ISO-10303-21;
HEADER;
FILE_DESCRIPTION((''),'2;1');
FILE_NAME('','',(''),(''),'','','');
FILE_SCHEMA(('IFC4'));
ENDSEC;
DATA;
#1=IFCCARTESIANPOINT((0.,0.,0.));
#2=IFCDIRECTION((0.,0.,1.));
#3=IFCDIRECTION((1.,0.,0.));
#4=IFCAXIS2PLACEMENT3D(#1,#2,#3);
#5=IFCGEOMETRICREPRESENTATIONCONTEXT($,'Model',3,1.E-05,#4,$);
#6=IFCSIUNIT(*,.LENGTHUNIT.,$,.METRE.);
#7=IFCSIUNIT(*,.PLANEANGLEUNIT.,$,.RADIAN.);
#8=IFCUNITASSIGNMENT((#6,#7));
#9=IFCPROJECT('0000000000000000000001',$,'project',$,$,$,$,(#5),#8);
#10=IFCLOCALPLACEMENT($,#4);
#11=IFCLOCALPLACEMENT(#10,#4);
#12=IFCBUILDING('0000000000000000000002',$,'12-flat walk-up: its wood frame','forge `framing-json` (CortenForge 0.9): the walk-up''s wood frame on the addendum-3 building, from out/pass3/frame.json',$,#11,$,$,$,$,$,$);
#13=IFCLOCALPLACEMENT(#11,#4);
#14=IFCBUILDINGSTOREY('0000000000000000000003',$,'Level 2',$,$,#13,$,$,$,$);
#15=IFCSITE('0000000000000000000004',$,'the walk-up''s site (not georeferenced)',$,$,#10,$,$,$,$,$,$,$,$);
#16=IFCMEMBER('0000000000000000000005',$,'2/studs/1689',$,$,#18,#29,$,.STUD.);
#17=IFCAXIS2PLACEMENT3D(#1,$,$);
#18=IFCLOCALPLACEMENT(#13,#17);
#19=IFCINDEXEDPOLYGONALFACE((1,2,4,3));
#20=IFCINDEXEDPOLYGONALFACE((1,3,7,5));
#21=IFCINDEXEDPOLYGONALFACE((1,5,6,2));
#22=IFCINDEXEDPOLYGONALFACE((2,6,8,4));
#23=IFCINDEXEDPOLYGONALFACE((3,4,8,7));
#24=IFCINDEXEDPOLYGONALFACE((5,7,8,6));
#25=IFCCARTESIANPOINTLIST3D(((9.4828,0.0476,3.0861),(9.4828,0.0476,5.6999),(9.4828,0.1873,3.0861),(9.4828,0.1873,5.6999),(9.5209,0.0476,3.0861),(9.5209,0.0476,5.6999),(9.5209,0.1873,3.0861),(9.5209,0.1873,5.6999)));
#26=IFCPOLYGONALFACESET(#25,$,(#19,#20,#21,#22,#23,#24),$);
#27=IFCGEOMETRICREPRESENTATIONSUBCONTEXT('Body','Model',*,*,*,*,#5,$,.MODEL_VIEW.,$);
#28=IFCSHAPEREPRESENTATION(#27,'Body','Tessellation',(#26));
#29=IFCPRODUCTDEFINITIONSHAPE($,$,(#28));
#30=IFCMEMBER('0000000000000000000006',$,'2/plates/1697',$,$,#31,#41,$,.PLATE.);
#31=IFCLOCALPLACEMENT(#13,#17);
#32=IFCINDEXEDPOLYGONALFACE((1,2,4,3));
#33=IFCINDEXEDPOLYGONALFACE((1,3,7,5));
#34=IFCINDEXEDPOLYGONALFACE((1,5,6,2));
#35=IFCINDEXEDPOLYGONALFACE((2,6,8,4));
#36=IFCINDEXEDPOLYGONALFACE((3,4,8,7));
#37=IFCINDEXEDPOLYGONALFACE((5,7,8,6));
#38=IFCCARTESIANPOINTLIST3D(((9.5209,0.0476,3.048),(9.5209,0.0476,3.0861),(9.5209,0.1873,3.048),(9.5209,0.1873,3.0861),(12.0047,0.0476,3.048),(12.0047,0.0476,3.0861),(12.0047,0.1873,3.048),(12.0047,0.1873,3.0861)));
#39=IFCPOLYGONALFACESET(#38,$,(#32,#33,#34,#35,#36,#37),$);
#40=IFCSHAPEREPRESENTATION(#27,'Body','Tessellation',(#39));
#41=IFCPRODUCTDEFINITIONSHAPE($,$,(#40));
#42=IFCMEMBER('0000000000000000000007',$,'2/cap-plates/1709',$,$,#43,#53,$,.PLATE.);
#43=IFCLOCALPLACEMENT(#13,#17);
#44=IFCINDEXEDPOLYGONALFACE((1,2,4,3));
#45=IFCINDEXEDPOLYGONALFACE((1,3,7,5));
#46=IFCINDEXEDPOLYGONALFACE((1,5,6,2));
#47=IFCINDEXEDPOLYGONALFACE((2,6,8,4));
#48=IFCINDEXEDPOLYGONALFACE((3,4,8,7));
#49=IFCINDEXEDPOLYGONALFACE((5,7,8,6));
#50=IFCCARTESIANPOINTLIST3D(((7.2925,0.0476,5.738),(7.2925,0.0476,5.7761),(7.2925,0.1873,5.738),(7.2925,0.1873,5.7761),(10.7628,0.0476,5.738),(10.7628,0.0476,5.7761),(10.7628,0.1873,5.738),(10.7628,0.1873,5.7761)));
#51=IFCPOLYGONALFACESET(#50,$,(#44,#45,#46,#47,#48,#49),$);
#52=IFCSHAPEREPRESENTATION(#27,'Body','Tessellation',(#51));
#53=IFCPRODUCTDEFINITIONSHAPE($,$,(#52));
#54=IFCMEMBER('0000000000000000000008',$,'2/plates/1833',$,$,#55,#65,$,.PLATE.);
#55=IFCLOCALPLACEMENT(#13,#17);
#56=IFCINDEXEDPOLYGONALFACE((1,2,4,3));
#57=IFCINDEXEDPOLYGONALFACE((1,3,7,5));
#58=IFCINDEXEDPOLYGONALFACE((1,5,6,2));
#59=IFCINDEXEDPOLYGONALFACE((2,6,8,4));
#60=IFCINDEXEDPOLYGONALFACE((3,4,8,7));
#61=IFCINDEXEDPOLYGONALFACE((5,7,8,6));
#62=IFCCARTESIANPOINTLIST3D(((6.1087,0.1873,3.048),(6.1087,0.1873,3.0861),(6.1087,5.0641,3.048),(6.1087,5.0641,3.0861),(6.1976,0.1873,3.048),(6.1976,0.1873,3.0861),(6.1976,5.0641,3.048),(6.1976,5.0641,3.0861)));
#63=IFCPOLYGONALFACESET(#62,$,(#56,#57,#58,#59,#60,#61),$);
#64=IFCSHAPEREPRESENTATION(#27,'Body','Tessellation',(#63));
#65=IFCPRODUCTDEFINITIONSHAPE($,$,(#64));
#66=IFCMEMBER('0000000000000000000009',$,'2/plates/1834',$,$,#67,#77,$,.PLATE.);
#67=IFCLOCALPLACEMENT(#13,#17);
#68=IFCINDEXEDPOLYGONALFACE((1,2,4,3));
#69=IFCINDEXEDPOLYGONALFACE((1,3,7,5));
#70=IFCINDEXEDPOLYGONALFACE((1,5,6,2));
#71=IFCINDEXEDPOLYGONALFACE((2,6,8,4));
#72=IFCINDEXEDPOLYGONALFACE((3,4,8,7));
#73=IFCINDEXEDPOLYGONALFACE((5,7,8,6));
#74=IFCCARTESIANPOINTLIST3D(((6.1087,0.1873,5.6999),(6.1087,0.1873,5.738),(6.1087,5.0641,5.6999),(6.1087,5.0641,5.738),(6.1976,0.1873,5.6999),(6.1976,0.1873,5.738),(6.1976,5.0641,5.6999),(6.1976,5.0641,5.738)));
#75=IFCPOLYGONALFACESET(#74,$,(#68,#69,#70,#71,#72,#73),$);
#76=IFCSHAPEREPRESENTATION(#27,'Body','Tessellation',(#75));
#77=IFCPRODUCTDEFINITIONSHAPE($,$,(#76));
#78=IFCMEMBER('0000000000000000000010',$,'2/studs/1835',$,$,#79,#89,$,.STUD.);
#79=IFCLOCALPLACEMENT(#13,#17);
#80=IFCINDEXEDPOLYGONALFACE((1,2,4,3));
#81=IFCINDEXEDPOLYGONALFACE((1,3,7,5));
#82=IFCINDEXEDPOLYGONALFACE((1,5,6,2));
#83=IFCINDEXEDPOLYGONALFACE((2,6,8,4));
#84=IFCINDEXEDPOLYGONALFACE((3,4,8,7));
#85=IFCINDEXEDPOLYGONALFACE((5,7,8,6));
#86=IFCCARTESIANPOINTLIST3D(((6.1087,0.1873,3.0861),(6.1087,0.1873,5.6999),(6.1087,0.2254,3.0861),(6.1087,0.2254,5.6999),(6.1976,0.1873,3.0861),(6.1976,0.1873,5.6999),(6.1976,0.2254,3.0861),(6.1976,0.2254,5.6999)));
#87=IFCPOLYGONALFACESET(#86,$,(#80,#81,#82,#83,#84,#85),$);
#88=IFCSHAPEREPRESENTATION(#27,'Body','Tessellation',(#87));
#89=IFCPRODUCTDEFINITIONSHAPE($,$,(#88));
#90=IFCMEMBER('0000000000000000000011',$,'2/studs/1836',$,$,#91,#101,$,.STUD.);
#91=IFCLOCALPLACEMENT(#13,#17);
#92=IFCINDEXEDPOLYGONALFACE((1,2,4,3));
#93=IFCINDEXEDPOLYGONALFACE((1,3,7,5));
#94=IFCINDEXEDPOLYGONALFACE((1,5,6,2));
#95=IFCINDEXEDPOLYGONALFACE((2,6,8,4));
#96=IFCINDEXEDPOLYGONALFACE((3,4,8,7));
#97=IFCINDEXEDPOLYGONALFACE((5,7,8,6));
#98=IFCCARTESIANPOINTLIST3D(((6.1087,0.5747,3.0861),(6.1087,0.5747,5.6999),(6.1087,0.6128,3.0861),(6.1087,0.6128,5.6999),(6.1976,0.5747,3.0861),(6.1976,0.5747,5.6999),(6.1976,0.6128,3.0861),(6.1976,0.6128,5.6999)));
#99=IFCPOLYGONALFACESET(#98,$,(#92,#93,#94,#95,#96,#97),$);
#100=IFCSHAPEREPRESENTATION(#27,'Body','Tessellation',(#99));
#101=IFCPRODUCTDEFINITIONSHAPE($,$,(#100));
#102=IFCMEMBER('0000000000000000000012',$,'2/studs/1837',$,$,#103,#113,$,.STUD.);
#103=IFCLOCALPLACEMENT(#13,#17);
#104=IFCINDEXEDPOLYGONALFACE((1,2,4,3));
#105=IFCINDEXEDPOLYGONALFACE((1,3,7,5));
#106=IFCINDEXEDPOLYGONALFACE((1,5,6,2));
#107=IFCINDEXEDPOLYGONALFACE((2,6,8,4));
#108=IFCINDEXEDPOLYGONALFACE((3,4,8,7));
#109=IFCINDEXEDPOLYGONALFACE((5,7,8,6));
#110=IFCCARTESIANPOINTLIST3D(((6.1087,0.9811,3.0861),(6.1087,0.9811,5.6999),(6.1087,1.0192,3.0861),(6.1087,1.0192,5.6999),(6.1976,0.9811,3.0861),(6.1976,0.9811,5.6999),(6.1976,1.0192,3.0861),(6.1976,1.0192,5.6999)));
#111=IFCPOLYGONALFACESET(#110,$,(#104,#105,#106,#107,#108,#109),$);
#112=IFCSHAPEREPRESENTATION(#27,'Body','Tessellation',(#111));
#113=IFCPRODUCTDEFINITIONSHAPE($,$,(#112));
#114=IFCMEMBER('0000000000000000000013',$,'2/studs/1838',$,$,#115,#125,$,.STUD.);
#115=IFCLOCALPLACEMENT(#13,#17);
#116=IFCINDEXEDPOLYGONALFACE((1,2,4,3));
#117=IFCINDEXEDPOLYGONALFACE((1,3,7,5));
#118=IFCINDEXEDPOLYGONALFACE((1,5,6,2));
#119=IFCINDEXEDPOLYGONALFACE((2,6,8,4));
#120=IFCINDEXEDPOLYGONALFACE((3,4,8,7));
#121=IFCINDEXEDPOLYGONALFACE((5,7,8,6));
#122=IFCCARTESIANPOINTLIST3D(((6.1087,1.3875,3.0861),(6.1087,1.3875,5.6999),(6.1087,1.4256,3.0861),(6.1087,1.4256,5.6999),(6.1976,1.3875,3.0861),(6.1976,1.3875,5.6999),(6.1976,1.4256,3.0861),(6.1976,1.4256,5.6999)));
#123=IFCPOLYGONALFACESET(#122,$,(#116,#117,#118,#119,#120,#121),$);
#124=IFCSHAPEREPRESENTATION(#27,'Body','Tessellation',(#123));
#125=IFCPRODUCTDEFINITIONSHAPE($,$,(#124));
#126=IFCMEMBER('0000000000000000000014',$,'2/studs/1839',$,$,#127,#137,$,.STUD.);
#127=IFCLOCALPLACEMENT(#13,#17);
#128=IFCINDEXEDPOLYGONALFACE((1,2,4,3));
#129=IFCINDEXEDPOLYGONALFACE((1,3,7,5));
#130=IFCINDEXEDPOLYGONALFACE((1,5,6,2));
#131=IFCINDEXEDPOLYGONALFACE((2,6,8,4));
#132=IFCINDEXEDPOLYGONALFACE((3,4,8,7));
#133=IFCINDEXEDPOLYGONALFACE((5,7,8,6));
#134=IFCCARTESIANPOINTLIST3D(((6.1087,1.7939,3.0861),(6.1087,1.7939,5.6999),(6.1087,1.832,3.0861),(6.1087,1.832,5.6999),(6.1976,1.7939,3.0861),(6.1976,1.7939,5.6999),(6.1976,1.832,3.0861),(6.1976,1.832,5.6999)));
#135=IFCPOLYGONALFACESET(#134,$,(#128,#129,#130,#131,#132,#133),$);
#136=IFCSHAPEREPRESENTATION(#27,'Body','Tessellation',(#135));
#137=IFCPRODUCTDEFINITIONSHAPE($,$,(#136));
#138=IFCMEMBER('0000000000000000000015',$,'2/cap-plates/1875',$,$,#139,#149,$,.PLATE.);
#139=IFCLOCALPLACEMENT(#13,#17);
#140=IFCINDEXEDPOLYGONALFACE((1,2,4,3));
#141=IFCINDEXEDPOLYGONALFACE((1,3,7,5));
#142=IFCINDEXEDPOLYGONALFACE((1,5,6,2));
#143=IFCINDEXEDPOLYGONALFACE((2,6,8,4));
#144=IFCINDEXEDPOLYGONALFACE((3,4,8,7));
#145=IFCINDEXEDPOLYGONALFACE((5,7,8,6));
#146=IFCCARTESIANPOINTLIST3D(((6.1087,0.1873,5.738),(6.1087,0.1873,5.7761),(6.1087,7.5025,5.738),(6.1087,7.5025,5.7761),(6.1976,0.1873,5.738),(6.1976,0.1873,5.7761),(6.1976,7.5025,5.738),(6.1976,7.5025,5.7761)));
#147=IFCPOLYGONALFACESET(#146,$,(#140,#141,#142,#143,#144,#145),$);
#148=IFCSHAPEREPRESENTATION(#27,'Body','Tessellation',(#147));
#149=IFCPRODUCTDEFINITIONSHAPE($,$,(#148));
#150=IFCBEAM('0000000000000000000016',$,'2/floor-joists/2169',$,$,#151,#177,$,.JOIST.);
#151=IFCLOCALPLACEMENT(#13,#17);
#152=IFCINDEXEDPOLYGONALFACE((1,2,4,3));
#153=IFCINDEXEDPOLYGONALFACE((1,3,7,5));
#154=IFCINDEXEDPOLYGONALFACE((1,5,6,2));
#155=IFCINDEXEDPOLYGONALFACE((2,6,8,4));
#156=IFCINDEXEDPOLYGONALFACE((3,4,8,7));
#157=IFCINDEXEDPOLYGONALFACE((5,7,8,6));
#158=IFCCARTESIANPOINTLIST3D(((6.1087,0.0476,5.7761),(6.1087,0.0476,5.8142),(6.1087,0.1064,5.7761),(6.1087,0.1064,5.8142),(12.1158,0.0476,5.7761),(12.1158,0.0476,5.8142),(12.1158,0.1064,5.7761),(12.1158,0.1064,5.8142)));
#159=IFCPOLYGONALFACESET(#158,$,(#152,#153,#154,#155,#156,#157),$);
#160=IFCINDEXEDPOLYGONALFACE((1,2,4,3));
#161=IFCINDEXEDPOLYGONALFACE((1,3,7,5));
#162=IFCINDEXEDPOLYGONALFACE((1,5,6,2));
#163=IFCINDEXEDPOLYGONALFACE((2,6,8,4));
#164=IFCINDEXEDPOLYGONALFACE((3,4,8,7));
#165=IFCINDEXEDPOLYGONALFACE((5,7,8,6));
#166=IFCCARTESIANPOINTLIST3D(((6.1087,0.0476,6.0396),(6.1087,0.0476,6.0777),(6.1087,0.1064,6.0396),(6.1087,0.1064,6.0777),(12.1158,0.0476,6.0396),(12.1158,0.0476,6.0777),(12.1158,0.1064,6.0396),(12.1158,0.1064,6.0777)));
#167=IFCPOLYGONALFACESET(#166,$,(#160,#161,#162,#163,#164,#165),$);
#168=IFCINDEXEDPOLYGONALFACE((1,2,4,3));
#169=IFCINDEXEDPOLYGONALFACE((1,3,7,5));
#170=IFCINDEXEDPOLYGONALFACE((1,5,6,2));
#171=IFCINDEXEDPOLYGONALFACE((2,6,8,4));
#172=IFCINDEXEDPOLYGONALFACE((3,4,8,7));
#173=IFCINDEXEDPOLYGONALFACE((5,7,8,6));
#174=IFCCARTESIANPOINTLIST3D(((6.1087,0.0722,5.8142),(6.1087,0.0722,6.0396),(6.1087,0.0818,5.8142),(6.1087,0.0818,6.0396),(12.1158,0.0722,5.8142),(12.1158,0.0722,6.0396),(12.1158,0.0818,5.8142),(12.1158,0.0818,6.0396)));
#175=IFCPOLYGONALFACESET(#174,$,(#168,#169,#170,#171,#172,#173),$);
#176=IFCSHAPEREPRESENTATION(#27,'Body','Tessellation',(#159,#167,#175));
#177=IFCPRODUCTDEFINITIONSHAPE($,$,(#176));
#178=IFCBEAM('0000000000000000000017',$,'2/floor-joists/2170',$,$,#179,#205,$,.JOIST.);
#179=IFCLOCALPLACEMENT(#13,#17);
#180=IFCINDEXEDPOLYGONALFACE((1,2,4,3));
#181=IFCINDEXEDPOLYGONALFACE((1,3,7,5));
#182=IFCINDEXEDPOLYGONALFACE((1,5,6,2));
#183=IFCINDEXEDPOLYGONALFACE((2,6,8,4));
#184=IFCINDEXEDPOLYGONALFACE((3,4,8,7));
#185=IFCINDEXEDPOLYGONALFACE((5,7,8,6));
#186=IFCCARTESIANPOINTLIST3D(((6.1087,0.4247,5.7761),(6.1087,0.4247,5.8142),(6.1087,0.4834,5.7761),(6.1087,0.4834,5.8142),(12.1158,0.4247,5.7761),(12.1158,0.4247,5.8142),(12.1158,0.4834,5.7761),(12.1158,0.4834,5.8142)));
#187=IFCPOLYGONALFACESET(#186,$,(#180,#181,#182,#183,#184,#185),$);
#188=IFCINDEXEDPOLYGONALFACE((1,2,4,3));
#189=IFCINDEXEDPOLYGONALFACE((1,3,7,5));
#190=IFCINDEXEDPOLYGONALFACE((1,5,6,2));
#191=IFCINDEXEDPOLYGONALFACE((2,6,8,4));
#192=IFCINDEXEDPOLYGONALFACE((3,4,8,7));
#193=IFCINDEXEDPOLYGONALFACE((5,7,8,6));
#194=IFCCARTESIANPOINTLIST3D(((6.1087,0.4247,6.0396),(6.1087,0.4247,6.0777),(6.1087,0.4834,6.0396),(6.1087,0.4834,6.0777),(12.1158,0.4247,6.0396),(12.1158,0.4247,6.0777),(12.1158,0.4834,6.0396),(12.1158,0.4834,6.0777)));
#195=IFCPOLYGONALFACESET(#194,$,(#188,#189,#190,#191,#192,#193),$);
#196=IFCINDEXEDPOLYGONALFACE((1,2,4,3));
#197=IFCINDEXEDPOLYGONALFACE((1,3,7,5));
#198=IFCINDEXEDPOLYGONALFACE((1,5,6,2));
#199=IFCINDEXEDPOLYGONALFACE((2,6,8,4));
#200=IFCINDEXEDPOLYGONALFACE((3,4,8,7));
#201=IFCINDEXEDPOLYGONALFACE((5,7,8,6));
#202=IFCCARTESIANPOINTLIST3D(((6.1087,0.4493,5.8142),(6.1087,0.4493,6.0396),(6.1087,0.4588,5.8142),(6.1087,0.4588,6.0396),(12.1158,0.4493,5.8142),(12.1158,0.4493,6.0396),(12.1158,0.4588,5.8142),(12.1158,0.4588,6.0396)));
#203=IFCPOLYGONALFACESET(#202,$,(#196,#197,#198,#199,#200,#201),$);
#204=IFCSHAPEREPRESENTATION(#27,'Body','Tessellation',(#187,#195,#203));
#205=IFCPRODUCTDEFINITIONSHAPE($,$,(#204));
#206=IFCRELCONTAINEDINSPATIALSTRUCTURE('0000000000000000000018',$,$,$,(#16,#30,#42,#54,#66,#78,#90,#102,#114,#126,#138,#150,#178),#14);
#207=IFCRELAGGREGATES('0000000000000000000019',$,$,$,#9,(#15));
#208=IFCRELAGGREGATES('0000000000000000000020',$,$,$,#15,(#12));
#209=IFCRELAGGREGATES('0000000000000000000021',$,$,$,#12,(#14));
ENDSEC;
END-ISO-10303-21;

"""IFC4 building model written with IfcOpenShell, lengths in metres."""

from ifc_helpers import new_model, si_unit, frame, frame_2d, origin, origin_with_axes, place, context, subcontext, project, spatial, rectangle, extrude, element, save


model = new_model("IFC4")

# Units and contexts
model_context = context("Model", 3, precision=1e-05, world=origin_with_axes())
body_context = subcontext(model_context, "Body", "Model", "MODEL_VIEW")
ifc_project = project(units=[si_unit("LENGTHUNIT", "METRE"), si_unit("PLANEANGLEUNIT", "RADIAN")], contexts=[model_context])

# Site, building, storey
site_placement = place(None, origin_with_axes())
site = spatial("IfcSite", under=ifc_project, at=site_placement, Name="the walk-up's site (not georeferenced)")
building_placement = place(site_placement, origin_with_axes())
building = spatial("IfcBuilding", under=site, at=building_placement, Name="12-flat walk-up: its wood frame", Description="forge `framing-json` (CortenForge 0.9): the walk-up's wood frame on the addendum-3 building, from out/pass3/frame.json")
storey_placement = place(building_placement, origin_with_axes())
storey = spatial("IfcBuildingStorey", under=building, at=storey_placement, Name="Level 2")

# Members
for number, where, z_axis, x_axis, name in (
    (1, (9.4828, 0.0476, 3.0861), (0.0, 0.0, 1.0), (1.0, 0.0, 0.0), "2/studs/1689"),
):
    element("IfcMember", number, at=place(storey_placement, frame(where, z_axis=z_axis, x_axis=x_axis)), inside=storey, Name=name, PredefinedType="STUD", context=body_context, shape_type="SweptSolid", body=[
        extrude(rectangle(XDim=0.0381, YDim=0.1397, at=frame_2d((0.0191, 0.0698))), origin(), (0.0, 0.0, 1.0), 2.6138),
    ])
member_1_placement = place(storey_placement, frame((9.5209, 0.0476, 3.048), z_axis=(0.0, 0.0, 1.0), x_axis=(1.0, 0.0, 0.0)))
element("IfcMember", 2, at=member_1_placement, inside=storey, Name="2/plates/1697", PredefinedType="PLATE", context=body_context, shape_type="SweptSolid", body=[
    extrude(rectangle(XDim=2.4838, YDim=0.1397, at=frame_2d((1.2419, 0.0698))), origin(), (0.0, 0.0, 1.0), 0.0381),
])
member_2_placement = place(storey_placement, frame((7.2925, 0.0476, 5.738), z_axis=(0.0, 0.0, 1.0), x_axis=(1.0, 0.0, 0.0)))
element("IfcMember", 3, at=member_2_placement, inside=storey, Name="2/cap-plates/1709", PredefinedType="PLATE", context=body_context, shape_type="SweptSolid", body=[
    extrude(rectangle(XDim=3.4703, YDim=0.1397, at=frame_2d((1.7351, 0.0698))), origin(), (0.0, 0.0, 1.0), 0.0381),
])
for number, where, z_axis, x_axis, name in (
    (4, (6.1087, 0.1873, 3.048), (0.0, 0.0, 1.0), (1.0, 0.0, 0.0), "2/plates/1833"),
    (5, (6.1087, 0.1873, 5.6999), (0.0, 0.0, 1.0), (1.0, 0.0, 0.0), "2/plates/1834"),
):
    element("IfcMember", number, at=place(storey_placement, frame(where, z_axis=z_axis, x_axis=x_axis)), inside=storey, Name=name, PredefinedType="PLATE", context=body_context, shape_type="SweptSolid", body=[
        extrude(rectangle(XDim=0.0889, YDim=4.8768, at=frame_2d((0.0445, 2.4384))), origin(), (0.0, 0.0, 1.0), 0.0381),
    ])
member_3_placement = place(storey_placement, frame((6.1087, 0.1873, 3.0861), z_axis=(0.0, 0.0, 1.0), x_axis=(1.0, 0.0, 0.0)))
element("IfcMember", 6, at=member_3_placement, inside=storey, Name="2/studs/1835", PredefinedType="STUD", context=body_context, shape_type="SweptSolid", body=[
    extrude(rectangle(XDim=0.0889, YDim=0.0381, at=frame_2d((0.0445, 0.019))), origin(), (0.0, 0.0, 1.0), 2.6138),
])
for number, where, z_axis, x_axis, name in (
    (7, (6.1087, 0.5747, 3.0861), (0.0, 0.0, 1.0), (1.0, 0.0, 0.0), "2/studs/1836"),
    (8, (6.1087, 0.9811, 3.0861), (0.0, 0.0, 1.0), (1.0, 0.0, 0.0), "2/studs/1837"),
):
    element("IfcMember", number, at=place(storey_placement, frame(where, z_axis=z_axis, x_axis=x_axis)), inside=storey, Name=name, PredefinedType="STUD", context=body_context, shape_type="SweptSolid", body=[
        extrude(rectangle(XDim=0.0889, YDim=0.0381, at=frame_2d((0.0445, 0.019))), origin(), (0.0, 0.0, 1.0), 2.6138),
    ])
member_4_placement = place(storey_placement, frame((6.1087, 1.3875, 3.0861), z_axis=(0.0, 0.0, 1.0), x_axis=(1.0, 0.0, 0.0)))
element("IfcMember", 9, at=member_4_placement, inside=storey, Name="2/studs/1838", PredefinedType="STUD", context=body_context, shape_type="SweptSolid", body=[
    extrude(rectangle(XDim=0.0889, YDim=0.0381, at=frame_2d((0.0445, 0.0191))), origin(), (0.0, 0.0, 1.0), 2.6138),
])
member_5_placement = place(storey_placement, frame((6.1087, 1.7939, 3.0861), z_axis=(0.0, 0.0, 1.0), x_axis=(1.0, 0.0, 0.0)))
element("IfcMember", 10, at=member_5_placement, inside=storey, Name="2/studs/1839", PredefinedType="STUD", context=body_context, shape_type="SweptSolid", body=[
    extrude(rectangle(XDim=0.0889, YDim=0.0381, at=frame_2d((0.0445, 0.019))), origin(), (0.0, 0.0, 1.0), 2.6138),
])
member_6_placement = place(storey_placement, frame((6.1087, 0.1873, 5.738), z_axis=(0.0, 0.0, 1.0), x_axis=(1.0, 0.0, 0.0)))
element("IfcMember", 11, at=member_6_placement, inside=storey, Name="2/cap-plates/1875", PredefinedType="PLATE", context=body_context, shape_type="SweptSolid", body=[
    extrude(rectangle(XDim=0.0889, YDim=7.3152, at=frame_2d((0.0445, 3.6576))), origin(), (0.0, 0.0, 1.0), 0.0381),
])

# Beams
beam_1_placement = place(storey_placement, frame((6.1087, 0.0476, 5.7761), z_axis=(0.0, 0.0, 1.0), x_axis=(1.0, 0.0, 0.0)))
element("IfcBeam", 12, at=beam_1_placement, inside=storey, Name="2/floor-joists/2169", PredefinedType="JOIST", context=body_context, shape_type="SweptSolid", body=[
    extrude(rectangle(XDim=6.0071, YDim=0.0587, at=frame_2d((3.0036, 0.0294))), origin(), (0.0, 0.0, 1.0), 0.0381),
    extrude(rectangle(XDim=6.0071, YDim=0.0587, at=frame_2d((3.0036, 0.0294))), frame((0.0, 0.0, 0.2635)), (0.0, 0.0, 1.0), 0.0381),
    extrude(rectangle(XDim=6.0071, YDim=0.0095, at=frame_2d((3.0036, 0.0048))), frame((0.0, 0.0246, 0.0381)), (0.0, 0.0, 1.0), 0.2254),
])
beam_2_placement = place(storey_placement, frame((6.1087, 0.4247, 5.7761), z_axis=(0.0, 0.0, 1.0), x_axis=(1.0, 0.0, 0.0)))
element("IfcBeam", 13, at=beam_2_placement, inside=storey, Name="2/floor-joists/2170", PredefinedType="JOIST", context=body_context, shape_type="SweptSolid", body=[
    extrude(rectangle(XDim=6.0071, YDim=0.0587, at=frame_2d((3.0036, 0.0294))), origin(), (0.0, 0.0, 1.0), 0.0381),
    extrude(rectangle(XDim=6.0071, YDim=0.0587, at=frame_2d((3.0036, 0.0294))), frame((0.0, 0.0, 0.2635)), (0.0, 0.0, 1.0), 0.0381),
    extrude(rectangle(XDim=6.0071, YDim=0.0095, at=frame_2d((3.0036, 0.0048))), frame((0.0, 0.0246, 0.0381)), (0.0, 0.0, 1.0), 0.2254),
])

save(model, "model.ifc")
